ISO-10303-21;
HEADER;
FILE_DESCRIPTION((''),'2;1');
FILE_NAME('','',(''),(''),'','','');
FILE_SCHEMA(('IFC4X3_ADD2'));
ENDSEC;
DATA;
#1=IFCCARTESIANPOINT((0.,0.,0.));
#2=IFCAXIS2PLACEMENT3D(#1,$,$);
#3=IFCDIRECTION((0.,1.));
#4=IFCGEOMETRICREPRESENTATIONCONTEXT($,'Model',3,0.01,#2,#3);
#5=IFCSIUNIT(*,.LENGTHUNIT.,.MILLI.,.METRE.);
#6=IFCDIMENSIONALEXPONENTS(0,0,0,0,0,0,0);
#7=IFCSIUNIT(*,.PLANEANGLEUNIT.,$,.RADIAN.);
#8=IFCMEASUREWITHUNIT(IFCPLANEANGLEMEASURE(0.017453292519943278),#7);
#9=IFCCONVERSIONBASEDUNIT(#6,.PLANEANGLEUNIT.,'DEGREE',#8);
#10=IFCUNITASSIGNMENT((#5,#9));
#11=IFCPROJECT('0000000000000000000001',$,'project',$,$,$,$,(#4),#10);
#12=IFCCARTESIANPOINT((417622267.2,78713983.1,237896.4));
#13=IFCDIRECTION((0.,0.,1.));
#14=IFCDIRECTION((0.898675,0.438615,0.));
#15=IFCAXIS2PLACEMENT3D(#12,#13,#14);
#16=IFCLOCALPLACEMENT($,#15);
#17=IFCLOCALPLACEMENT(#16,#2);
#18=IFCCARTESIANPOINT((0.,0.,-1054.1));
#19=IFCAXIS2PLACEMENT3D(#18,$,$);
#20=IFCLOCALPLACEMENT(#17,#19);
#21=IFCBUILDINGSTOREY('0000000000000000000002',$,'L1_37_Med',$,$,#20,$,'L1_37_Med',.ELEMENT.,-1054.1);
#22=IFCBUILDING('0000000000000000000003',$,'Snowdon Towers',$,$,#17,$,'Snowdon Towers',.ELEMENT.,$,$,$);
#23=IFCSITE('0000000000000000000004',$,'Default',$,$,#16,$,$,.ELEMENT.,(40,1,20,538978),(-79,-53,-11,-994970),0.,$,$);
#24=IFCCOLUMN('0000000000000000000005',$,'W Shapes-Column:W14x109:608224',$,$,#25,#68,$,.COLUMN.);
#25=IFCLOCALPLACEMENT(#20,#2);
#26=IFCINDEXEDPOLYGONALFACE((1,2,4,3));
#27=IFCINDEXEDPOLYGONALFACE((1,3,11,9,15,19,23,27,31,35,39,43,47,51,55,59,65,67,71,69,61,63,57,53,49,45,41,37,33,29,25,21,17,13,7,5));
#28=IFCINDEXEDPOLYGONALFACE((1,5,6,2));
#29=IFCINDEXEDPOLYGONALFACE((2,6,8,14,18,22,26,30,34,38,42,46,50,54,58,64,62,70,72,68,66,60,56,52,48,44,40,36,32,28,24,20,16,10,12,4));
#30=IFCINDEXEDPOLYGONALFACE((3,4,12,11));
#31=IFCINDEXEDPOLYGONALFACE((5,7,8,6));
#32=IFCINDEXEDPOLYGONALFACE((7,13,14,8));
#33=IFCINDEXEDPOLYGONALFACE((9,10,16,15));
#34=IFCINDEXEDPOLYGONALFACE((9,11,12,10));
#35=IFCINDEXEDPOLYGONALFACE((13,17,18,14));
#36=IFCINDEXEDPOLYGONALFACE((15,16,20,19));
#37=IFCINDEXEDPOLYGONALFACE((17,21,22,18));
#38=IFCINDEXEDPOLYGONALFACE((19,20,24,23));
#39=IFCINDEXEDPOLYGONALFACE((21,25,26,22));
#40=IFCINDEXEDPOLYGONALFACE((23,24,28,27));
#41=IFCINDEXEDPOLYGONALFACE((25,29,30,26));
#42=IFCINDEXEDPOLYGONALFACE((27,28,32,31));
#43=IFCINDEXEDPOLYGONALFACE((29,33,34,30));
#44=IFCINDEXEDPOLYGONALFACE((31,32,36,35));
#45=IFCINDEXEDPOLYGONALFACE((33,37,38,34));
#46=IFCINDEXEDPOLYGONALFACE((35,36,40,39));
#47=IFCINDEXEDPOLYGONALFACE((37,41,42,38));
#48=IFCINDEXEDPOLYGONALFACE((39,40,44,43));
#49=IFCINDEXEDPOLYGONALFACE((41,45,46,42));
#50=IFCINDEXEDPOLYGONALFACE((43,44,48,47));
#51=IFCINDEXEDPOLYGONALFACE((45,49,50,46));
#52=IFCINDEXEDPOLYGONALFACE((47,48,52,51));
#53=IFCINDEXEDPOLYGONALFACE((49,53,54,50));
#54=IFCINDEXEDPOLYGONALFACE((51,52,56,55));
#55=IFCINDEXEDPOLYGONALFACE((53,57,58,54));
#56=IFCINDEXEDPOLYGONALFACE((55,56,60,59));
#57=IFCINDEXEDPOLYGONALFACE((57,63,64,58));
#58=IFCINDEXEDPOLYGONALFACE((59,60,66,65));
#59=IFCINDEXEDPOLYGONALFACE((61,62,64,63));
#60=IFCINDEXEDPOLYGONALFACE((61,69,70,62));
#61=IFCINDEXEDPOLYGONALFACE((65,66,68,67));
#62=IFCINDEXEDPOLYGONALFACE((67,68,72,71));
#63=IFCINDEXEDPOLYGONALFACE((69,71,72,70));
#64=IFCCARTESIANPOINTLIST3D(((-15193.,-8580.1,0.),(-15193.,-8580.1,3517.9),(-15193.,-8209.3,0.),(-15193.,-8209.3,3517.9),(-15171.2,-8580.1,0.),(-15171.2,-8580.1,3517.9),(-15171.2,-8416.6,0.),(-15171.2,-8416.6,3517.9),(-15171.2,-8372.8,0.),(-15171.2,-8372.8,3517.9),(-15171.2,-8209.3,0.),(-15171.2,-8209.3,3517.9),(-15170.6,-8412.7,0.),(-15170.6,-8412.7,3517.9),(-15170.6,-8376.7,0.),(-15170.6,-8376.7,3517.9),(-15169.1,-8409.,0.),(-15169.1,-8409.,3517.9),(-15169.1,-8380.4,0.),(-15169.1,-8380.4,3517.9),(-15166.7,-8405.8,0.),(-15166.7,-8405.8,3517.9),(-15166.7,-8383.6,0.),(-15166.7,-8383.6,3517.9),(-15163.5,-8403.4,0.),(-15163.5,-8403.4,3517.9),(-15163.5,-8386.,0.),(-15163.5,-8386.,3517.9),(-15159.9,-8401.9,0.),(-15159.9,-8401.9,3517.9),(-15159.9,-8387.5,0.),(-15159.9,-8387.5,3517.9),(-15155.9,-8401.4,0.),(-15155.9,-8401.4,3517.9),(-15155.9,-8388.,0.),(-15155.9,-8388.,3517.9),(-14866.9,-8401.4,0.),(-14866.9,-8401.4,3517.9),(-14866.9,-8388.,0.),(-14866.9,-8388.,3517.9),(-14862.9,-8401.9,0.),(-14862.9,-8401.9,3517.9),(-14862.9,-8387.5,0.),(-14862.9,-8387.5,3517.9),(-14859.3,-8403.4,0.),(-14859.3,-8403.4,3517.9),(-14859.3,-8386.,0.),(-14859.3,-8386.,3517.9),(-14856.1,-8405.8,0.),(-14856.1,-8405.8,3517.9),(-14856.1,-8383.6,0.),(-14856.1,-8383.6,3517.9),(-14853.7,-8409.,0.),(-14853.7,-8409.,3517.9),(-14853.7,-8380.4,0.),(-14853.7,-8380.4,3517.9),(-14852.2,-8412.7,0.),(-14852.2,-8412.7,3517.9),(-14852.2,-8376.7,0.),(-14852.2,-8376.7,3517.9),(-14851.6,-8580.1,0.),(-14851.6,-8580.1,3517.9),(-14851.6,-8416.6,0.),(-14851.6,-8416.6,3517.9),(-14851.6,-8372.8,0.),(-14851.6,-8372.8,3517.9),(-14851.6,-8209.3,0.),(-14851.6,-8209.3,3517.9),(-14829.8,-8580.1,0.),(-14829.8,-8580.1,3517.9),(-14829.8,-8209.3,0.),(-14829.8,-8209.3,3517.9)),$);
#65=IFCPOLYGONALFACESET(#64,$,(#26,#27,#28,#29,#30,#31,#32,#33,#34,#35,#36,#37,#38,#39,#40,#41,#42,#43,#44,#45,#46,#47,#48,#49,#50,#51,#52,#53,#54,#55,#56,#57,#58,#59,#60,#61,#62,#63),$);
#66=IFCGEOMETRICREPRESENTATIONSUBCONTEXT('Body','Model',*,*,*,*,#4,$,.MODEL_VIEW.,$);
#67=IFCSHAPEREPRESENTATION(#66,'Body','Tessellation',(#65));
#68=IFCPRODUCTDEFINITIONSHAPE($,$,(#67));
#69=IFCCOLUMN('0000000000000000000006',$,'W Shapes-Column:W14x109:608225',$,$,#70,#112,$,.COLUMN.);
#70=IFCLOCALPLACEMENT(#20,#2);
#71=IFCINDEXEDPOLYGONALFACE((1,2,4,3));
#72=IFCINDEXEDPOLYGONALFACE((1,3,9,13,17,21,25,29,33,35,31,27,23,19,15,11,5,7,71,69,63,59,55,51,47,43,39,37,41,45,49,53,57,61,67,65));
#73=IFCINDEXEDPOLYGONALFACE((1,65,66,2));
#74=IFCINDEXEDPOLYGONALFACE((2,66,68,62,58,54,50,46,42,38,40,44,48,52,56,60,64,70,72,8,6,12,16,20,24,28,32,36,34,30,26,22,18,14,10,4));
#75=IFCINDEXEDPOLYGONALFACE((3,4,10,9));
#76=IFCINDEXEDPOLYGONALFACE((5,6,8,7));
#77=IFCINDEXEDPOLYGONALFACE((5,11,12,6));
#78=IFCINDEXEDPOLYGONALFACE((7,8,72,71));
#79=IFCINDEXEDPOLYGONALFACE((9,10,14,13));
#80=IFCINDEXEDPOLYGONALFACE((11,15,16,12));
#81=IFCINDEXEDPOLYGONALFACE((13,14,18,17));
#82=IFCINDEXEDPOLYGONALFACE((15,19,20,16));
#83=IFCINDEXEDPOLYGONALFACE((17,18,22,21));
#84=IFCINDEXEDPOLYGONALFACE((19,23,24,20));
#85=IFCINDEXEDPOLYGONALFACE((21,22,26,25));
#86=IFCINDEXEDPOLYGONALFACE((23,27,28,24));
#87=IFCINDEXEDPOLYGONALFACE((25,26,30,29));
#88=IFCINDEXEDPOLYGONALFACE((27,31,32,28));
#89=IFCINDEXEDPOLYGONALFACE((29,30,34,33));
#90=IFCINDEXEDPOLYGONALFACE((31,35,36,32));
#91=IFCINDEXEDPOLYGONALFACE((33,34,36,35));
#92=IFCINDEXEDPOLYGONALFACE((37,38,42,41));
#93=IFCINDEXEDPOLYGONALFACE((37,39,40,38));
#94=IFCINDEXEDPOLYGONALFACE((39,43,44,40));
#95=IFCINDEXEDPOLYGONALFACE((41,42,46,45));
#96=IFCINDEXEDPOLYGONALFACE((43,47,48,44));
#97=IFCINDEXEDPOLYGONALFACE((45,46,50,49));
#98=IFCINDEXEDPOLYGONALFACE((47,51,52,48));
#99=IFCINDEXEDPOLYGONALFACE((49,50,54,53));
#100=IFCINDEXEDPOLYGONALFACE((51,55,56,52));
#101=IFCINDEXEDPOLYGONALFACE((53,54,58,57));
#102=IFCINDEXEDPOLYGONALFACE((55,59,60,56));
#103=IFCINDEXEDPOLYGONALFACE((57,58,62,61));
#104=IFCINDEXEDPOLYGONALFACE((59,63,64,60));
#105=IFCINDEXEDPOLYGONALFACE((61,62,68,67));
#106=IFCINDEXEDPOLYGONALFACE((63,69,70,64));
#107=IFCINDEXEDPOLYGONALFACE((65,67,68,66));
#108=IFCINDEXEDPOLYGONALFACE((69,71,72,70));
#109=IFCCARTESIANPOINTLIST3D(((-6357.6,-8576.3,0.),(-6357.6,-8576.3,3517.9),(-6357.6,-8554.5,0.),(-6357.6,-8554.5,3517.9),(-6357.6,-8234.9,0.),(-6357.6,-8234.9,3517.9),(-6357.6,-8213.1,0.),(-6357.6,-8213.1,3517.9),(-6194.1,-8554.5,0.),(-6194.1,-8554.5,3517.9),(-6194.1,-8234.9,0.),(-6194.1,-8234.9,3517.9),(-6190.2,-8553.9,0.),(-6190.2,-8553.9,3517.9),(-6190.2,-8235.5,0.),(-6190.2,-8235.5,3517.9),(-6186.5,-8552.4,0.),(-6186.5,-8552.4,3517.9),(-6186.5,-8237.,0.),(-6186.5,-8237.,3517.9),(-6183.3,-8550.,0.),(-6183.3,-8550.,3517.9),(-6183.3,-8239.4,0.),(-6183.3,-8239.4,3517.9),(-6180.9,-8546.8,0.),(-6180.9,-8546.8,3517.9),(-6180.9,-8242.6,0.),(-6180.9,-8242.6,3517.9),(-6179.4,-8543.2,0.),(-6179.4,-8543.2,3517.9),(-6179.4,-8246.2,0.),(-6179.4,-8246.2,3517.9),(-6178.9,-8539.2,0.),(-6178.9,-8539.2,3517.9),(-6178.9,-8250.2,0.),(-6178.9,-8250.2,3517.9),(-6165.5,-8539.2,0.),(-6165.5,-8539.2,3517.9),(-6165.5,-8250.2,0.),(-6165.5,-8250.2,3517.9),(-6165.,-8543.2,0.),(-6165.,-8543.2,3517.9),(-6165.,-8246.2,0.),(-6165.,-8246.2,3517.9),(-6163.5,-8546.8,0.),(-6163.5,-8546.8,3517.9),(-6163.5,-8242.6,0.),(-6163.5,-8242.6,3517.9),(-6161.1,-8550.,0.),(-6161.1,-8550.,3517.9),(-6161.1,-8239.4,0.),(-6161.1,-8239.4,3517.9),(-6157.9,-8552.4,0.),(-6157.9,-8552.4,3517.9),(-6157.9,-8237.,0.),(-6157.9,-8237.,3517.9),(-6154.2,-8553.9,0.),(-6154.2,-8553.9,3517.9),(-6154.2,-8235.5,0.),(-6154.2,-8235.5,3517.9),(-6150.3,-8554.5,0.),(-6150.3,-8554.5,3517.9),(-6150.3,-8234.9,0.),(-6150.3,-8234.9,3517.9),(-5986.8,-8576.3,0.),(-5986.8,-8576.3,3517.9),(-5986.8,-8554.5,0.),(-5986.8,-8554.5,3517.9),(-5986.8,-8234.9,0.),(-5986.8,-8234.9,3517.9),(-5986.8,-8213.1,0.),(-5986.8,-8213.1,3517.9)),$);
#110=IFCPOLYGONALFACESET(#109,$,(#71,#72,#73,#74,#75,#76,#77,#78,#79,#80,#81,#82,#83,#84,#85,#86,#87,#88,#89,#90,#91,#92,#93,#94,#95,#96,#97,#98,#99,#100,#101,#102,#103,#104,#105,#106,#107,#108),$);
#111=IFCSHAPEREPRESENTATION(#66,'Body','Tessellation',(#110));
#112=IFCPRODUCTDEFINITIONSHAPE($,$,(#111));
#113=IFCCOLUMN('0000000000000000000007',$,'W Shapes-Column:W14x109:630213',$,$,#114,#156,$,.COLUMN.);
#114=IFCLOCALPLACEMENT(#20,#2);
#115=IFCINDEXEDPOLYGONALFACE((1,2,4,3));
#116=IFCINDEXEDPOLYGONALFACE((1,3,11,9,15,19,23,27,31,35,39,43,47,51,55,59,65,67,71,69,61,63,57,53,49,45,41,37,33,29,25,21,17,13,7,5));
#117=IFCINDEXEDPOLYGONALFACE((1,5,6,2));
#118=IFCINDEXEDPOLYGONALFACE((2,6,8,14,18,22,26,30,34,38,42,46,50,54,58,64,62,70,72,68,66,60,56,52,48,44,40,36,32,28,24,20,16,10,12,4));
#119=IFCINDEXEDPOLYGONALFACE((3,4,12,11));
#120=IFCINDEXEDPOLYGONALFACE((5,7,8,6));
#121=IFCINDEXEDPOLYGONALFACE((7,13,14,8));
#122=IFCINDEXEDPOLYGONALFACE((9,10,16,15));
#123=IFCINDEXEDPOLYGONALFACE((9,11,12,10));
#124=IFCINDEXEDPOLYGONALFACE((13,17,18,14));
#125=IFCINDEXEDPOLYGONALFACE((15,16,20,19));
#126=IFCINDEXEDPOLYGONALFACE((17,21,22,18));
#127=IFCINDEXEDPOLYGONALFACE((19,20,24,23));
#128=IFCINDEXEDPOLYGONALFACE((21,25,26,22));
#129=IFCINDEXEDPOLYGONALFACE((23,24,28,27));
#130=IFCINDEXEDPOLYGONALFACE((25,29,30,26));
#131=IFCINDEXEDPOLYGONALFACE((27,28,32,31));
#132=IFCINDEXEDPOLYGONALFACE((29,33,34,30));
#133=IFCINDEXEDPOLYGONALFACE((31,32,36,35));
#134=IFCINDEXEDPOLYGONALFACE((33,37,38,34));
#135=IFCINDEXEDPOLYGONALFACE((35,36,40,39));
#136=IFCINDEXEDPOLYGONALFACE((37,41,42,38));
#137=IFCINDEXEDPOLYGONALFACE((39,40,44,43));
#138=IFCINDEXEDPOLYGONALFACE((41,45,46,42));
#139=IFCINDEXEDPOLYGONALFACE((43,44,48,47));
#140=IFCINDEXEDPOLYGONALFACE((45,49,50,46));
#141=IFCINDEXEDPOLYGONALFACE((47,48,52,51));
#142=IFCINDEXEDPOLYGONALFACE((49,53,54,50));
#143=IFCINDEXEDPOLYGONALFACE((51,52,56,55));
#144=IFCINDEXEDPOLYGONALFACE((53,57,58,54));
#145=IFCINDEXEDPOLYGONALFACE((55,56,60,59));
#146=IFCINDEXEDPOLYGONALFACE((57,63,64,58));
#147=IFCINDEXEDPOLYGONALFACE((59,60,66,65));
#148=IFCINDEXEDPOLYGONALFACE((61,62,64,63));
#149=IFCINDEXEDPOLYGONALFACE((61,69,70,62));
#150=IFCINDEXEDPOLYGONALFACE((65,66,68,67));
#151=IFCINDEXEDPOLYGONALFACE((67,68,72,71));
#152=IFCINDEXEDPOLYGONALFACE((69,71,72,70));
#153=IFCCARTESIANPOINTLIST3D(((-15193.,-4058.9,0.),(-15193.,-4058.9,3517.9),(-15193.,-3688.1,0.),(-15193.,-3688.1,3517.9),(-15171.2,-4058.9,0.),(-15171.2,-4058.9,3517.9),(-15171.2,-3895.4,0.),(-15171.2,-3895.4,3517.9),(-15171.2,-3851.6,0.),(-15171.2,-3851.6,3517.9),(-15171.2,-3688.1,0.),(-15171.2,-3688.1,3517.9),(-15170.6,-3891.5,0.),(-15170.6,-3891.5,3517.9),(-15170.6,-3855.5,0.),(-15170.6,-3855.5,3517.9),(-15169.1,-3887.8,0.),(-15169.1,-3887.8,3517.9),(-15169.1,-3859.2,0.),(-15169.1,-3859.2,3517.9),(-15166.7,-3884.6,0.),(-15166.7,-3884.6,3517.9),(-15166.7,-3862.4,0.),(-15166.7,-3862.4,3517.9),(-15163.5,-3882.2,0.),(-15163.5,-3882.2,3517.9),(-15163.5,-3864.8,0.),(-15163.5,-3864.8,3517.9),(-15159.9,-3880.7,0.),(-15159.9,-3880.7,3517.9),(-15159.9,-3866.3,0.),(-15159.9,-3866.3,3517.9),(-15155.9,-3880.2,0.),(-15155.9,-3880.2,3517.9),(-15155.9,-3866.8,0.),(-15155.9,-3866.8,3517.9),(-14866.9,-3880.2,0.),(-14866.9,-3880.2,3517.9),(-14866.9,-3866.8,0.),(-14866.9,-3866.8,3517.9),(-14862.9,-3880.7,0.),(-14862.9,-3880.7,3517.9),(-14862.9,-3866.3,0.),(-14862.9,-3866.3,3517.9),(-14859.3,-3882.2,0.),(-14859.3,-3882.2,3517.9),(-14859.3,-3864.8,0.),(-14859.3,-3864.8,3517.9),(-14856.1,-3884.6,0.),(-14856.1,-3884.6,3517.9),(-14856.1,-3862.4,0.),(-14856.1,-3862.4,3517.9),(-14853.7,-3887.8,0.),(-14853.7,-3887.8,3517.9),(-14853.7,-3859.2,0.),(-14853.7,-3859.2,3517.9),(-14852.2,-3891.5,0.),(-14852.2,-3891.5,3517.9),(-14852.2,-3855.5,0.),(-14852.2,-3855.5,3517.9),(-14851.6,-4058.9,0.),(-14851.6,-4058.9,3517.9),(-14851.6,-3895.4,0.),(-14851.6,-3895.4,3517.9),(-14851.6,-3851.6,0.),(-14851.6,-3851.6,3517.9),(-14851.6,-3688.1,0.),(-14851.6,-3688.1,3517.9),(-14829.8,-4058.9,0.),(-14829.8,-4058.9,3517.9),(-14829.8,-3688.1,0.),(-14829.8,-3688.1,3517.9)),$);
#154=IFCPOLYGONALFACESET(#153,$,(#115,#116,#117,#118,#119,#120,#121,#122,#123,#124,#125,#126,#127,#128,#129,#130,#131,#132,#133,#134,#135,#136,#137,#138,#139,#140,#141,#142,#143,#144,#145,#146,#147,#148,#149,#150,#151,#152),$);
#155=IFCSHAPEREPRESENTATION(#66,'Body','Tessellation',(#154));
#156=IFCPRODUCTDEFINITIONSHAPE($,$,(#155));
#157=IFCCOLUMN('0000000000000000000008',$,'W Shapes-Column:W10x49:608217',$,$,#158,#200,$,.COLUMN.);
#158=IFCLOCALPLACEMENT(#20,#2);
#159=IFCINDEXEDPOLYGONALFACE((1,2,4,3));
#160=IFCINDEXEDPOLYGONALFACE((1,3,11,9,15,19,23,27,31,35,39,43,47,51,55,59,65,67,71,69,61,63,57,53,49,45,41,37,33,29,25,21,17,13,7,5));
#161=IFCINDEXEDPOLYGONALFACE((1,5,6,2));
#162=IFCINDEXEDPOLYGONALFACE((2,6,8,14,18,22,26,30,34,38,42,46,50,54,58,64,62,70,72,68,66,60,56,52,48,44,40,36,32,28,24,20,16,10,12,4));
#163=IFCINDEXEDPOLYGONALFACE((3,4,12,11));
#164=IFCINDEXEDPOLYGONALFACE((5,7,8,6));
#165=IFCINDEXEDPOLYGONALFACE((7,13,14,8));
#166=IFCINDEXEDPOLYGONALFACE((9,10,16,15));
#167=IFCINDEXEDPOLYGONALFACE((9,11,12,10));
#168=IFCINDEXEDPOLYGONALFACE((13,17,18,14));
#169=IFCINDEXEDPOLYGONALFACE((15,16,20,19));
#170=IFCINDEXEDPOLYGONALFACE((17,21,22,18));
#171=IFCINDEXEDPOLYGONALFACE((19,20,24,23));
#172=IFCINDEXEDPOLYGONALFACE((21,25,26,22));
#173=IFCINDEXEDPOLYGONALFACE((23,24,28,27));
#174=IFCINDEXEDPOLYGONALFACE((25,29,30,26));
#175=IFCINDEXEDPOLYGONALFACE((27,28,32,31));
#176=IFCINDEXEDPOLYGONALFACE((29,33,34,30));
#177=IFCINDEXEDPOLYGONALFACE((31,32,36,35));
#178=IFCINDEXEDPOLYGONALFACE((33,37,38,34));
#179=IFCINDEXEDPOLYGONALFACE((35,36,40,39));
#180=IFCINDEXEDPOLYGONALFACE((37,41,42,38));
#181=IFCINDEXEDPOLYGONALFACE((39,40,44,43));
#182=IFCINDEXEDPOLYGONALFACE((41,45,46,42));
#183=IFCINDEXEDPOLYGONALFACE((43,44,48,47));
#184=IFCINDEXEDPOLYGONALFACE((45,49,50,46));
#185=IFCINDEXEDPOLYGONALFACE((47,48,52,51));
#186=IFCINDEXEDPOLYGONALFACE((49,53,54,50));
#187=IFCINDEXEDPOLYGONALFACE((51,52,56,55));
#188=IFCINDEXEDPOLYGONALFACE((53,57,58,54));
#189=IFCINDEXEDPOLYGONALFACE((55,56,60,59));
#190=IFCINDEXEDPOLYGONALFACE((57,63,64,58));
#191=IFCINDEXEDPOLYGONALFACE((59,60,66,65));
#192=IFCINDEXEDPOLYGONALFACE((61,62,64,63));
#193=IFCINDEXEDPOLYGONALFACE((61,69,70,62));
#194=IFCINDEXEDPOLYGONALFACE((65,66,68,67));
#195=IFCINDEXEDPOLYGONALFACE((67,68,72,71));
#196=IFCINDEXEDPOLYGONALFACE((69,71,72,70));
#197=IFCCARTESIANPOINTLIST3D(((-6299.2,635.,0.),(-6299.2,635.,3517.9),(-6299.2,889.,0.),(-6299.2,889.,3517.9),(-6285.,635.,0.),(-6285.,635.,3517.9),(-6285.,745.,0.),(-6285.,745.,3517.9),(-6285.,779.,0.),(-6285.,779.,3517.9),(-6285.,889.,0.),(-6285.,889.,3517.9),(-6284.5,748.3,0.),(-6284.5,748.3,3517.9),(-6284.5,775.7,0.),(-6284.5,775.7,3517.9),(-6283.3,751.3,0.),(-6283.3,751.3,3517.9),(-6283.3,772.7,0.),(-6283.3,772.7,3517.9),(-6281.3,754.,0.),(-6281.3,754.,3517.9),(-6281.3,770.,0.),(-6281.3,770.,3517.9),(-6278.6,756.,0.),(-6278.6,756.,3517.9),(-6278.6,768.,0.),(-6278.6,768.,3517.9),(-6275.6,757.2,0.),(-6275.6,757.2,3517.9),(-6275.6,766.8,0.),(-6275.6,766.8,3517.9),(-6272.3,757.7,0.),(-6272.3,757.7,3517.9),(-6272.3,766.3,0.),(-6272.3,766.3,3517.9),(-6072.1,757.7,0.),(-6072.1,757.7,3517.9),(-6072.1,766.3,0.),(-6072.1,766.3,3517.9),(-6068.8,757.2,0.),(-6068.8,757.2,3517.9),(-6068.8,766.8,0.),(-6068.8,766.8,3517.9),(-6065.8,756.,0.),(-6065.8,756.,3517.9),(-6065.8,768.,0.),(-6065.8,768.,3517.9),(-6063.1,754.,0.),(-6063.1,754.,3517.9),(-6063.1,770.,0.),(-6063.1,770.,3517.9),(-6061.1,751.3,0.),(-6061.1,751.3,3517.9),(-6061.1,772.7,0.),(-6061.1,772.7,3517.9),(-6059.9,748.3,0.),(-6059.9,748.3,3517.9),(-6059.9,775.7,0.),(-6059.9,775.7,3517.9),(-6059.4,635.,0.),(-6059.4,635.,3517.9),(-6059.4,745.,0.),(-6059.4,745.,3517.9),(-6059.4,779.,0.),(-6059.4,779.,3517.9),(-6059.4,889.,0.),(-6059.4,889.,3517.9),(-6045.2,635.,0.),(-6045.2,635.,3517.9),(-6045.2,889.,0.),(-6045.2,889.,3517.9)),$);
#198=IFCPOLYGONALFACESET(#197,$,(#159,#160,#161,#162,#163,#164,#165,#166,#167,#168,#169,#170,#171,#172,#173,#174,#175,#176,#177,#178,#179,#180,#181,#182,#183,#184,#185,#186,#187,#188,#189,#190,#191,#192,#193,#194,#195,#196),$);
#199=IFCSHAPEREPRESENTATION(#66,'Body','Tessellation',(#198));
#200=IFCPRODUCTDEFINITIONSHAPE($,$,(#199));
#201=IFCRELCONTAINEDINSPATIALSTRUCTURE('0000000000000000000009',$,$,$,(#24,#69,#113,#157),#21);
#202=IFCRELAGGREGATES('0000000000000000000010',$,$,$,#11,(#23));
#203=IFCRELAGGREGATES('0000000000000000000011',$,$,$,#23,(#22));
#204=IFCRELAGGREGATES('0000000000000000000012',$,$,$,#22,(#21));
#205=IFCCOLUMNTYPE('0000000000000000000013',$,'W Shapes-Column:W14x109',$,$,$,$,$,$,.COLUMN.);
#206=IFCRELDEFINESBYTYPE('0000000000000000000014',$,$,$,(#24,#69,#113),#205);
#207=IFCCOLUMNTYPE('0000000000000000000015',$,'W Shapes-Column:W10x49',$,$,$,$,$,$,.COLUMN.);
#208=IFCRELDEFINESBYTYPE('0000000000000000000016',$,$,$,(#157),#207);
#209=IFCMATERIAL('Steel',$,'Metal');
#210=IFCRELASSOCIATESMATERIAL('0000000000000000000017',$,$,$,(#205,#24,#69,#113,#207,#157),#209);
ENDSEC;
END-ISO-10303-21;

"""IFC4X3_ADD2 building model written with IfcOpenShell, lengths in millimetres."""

from ifc_helpers import new_model, entity, si_unit, converted_unit, direction, frame, frame_2d, origin, place, context, subcontext, project, spatial, i_section, extrude, source, transform, mapped, material, material_profile, profile_set, profile_usage, type_object, type_shapes, element, save


model = new_model("IFC4X3_ADD2")

# Units and contexts
model_context = context("Model", 3, precision=0.01, world=origin(), true_north=direction((0.0, 1.0)))
body_context = subcontext(model_context, "Body", "Model", "MODEL_VIEW")
ifc_project = project(units=[si_unit("LENGTHUNIT", "METRE", prefix="MILLI"), converted_unit("PLANEANGLEUNIT", "DEGREE", entity("IfcPlaneAngleMeasure", 0.017453292519943278), si_unit("PLANEANGLEUNIT", "RADIAN"), dimensions=[0, 0, 0, 0, 0, 0, 0])], contexts=[model_context])

# Site, building, storey
site_placement = place(None, frame((417622267.2, 78713983.1, 237896.4), z_axis=(0.0, 0.0, 1.0), x_axis=(0.898675, 0.438615, 0.0)))
site = spatial("IfcSite", under=ifc_project, at=site_placement, Name="Default", CompositionType="ELEMENT", RefLatitude=(40, 1, 20, 538978), RefLongitude=(-79, -53, -11, -994970), RefElevation=0.0)
building_placement = place(site_placement, origin())
building = spatial("IfcBuilding", under=site, at=building_placement, Name="Snowdon Towers", LongName="Snowdon Towers", CompositionType="ELEMENT")
storey_placement = place(building_placement, frame((0.0, 0.0, -1054.1)))
storey = spatial("IfcBuildingStorey", under=building, at=storey_placement, Name="L1_37_Med", LongName="L1_37_Med", CompositionType="ELEMENT", Elevation=-1054.1)

# Columns
ifc_material_1 = material(Name="Steel", Category="Metal")
ifc_material_profile_1 = material_profile(ifc_material_1, i_section(OverallWidth=370.8, OverallDepth=363.2, WebThickness=13.3, FlangeThickness=21.8, FilletRadius=15.2, at=frame_2d((0.0, 0.0), x_axis=(1.0, 0.0))), Name="W14x109")
ifc_profile_set_1 = profile_set([ifc_material_profile_1], Name="W14x109")
ifc_profile_usage_1 = profile_usage(ifc_profile_set_1)
column_type_1 = type_object("IfcColumnType", Name="W Shapes-Column:W14x109", PredefinedType="COLUMN", material=ifc_profile_set_1)
shared_shape_1 = source(origin(), body_context, "Body", "SweptSolid", [
    extrude(i_section(OverallWidth=370.8, OverallDepth=363.2, WebThickness=13.3, FlangeThickness=21.8, FilletRadius=15.2, at=frame_2d((0.0, 0.0), x_axis=(1.0, 0.0))), frame((0.0, 0.0, -1054.1), z_axis=(0.0, 0.0, 1.0), x_axis=(-1.0, 0.0, 0.0)), (0.0, 0.0, 1.0), 3517.9),
])
type_shapes(column_type_1, [shared_shape_1])
for number, where, z_axis, x_axis, name in (
    (1, (-15011.4, -8394.7, 1054.1), (0.0, 0.0, 1.0), (0.0, 1.0, 0.0), "W Shapes-Column:W14x109:608224"),
    (2, (-6172.2, -8394.7, 1054.1), (0.0, 0.0, 1.0), (-1.0, 0.0, 0.0), "W Shapes-Column:W14x109:608225"),
    (3, (-15011.4, -3873.5, 1054.1), (0.0, 0.0, 1.0), (0.0, 1.0, 0.0), "W Shapes-Column:W14x109:630213"),
):
    element("IfcColumn", number, at=place(storey_placement, frame(where, z_axis=z_axis, x_axis=x_axis)), inside=storey, type_object=column_type_1, material=ifc_profile_usage_1, Name=name, PredefinedType="COLUMN", context=body_context, shape_type="MappedRepresentation", body=[
        mapped(shared_shape_1, transform((0.0, 0.0, 0.0), scale=1.0)),
    ])
ifc_material_profile_2 = material_profile(ifc_material_1, i_section(OverallWidth=254.0, OverallDepth=254.0, WebThickness=8.6, FlangeThickness=14.2, FilletRadius=12.7, at=frame_2d((0.0, 0.0), x_axis=(1.0, 0.0))), Name="W10x49")
ifc_profile_set_2 = profile_set([ifc_material_profile_2], Name="W10x49")
ifc_profile_usage_2 = profile_usage(ifc_profile_set_2)
column_type_2 = type_object("IfcColumnType", Name="W Shapes-Column:W10x49", PredefinedType="COLUMN", material=ifc_profile_set_2)
shared_shape_2 = source(origin(), body_context, "Body", "SweptSolid", [
    extrude(i_section(OverallWidth=254.0, OverallDepth=254.0, WebThickness=8.6, FlangeThickness=14.2, FilletRadius=12.7, at=frame_2d((0.0, 0.0), x_axis=(1.0, 0.0))), frame((0.0, 0.0, -1054.1), z_axis=(0.0, 0.0, 1.0), x_axis=(-1.0, 0.0, 0.0)), (0.0, 0.0, 1.0), 3517.9),
])
type_shapes(column_type_2, [shared_shape_2])
for number, where, z_axis, x_axis, name in (
    (4, (-6172.2, 762.0, 1054.1), (0.0, 0.0, 1.0), (0.0, 1.0, 0.0), "W Shapes-Column:W10x49:608217"),
):
    element("IfcColumn", number, at=place(storey_placement, frame(where, z_axis=z_axis, x_axis=x_axis)), inside=storey, type_object=column_type_2, material=ifc_profile_usage_2, Name=name, PredefinedType="COLUMN", context=body_context, shape_type="MappedRepresentation", body=[
        mapped(shared_shape_2, transform((0.0, 0.0, 0.0), scale=1.0)),
    ])

save(model, "model.ifc")
